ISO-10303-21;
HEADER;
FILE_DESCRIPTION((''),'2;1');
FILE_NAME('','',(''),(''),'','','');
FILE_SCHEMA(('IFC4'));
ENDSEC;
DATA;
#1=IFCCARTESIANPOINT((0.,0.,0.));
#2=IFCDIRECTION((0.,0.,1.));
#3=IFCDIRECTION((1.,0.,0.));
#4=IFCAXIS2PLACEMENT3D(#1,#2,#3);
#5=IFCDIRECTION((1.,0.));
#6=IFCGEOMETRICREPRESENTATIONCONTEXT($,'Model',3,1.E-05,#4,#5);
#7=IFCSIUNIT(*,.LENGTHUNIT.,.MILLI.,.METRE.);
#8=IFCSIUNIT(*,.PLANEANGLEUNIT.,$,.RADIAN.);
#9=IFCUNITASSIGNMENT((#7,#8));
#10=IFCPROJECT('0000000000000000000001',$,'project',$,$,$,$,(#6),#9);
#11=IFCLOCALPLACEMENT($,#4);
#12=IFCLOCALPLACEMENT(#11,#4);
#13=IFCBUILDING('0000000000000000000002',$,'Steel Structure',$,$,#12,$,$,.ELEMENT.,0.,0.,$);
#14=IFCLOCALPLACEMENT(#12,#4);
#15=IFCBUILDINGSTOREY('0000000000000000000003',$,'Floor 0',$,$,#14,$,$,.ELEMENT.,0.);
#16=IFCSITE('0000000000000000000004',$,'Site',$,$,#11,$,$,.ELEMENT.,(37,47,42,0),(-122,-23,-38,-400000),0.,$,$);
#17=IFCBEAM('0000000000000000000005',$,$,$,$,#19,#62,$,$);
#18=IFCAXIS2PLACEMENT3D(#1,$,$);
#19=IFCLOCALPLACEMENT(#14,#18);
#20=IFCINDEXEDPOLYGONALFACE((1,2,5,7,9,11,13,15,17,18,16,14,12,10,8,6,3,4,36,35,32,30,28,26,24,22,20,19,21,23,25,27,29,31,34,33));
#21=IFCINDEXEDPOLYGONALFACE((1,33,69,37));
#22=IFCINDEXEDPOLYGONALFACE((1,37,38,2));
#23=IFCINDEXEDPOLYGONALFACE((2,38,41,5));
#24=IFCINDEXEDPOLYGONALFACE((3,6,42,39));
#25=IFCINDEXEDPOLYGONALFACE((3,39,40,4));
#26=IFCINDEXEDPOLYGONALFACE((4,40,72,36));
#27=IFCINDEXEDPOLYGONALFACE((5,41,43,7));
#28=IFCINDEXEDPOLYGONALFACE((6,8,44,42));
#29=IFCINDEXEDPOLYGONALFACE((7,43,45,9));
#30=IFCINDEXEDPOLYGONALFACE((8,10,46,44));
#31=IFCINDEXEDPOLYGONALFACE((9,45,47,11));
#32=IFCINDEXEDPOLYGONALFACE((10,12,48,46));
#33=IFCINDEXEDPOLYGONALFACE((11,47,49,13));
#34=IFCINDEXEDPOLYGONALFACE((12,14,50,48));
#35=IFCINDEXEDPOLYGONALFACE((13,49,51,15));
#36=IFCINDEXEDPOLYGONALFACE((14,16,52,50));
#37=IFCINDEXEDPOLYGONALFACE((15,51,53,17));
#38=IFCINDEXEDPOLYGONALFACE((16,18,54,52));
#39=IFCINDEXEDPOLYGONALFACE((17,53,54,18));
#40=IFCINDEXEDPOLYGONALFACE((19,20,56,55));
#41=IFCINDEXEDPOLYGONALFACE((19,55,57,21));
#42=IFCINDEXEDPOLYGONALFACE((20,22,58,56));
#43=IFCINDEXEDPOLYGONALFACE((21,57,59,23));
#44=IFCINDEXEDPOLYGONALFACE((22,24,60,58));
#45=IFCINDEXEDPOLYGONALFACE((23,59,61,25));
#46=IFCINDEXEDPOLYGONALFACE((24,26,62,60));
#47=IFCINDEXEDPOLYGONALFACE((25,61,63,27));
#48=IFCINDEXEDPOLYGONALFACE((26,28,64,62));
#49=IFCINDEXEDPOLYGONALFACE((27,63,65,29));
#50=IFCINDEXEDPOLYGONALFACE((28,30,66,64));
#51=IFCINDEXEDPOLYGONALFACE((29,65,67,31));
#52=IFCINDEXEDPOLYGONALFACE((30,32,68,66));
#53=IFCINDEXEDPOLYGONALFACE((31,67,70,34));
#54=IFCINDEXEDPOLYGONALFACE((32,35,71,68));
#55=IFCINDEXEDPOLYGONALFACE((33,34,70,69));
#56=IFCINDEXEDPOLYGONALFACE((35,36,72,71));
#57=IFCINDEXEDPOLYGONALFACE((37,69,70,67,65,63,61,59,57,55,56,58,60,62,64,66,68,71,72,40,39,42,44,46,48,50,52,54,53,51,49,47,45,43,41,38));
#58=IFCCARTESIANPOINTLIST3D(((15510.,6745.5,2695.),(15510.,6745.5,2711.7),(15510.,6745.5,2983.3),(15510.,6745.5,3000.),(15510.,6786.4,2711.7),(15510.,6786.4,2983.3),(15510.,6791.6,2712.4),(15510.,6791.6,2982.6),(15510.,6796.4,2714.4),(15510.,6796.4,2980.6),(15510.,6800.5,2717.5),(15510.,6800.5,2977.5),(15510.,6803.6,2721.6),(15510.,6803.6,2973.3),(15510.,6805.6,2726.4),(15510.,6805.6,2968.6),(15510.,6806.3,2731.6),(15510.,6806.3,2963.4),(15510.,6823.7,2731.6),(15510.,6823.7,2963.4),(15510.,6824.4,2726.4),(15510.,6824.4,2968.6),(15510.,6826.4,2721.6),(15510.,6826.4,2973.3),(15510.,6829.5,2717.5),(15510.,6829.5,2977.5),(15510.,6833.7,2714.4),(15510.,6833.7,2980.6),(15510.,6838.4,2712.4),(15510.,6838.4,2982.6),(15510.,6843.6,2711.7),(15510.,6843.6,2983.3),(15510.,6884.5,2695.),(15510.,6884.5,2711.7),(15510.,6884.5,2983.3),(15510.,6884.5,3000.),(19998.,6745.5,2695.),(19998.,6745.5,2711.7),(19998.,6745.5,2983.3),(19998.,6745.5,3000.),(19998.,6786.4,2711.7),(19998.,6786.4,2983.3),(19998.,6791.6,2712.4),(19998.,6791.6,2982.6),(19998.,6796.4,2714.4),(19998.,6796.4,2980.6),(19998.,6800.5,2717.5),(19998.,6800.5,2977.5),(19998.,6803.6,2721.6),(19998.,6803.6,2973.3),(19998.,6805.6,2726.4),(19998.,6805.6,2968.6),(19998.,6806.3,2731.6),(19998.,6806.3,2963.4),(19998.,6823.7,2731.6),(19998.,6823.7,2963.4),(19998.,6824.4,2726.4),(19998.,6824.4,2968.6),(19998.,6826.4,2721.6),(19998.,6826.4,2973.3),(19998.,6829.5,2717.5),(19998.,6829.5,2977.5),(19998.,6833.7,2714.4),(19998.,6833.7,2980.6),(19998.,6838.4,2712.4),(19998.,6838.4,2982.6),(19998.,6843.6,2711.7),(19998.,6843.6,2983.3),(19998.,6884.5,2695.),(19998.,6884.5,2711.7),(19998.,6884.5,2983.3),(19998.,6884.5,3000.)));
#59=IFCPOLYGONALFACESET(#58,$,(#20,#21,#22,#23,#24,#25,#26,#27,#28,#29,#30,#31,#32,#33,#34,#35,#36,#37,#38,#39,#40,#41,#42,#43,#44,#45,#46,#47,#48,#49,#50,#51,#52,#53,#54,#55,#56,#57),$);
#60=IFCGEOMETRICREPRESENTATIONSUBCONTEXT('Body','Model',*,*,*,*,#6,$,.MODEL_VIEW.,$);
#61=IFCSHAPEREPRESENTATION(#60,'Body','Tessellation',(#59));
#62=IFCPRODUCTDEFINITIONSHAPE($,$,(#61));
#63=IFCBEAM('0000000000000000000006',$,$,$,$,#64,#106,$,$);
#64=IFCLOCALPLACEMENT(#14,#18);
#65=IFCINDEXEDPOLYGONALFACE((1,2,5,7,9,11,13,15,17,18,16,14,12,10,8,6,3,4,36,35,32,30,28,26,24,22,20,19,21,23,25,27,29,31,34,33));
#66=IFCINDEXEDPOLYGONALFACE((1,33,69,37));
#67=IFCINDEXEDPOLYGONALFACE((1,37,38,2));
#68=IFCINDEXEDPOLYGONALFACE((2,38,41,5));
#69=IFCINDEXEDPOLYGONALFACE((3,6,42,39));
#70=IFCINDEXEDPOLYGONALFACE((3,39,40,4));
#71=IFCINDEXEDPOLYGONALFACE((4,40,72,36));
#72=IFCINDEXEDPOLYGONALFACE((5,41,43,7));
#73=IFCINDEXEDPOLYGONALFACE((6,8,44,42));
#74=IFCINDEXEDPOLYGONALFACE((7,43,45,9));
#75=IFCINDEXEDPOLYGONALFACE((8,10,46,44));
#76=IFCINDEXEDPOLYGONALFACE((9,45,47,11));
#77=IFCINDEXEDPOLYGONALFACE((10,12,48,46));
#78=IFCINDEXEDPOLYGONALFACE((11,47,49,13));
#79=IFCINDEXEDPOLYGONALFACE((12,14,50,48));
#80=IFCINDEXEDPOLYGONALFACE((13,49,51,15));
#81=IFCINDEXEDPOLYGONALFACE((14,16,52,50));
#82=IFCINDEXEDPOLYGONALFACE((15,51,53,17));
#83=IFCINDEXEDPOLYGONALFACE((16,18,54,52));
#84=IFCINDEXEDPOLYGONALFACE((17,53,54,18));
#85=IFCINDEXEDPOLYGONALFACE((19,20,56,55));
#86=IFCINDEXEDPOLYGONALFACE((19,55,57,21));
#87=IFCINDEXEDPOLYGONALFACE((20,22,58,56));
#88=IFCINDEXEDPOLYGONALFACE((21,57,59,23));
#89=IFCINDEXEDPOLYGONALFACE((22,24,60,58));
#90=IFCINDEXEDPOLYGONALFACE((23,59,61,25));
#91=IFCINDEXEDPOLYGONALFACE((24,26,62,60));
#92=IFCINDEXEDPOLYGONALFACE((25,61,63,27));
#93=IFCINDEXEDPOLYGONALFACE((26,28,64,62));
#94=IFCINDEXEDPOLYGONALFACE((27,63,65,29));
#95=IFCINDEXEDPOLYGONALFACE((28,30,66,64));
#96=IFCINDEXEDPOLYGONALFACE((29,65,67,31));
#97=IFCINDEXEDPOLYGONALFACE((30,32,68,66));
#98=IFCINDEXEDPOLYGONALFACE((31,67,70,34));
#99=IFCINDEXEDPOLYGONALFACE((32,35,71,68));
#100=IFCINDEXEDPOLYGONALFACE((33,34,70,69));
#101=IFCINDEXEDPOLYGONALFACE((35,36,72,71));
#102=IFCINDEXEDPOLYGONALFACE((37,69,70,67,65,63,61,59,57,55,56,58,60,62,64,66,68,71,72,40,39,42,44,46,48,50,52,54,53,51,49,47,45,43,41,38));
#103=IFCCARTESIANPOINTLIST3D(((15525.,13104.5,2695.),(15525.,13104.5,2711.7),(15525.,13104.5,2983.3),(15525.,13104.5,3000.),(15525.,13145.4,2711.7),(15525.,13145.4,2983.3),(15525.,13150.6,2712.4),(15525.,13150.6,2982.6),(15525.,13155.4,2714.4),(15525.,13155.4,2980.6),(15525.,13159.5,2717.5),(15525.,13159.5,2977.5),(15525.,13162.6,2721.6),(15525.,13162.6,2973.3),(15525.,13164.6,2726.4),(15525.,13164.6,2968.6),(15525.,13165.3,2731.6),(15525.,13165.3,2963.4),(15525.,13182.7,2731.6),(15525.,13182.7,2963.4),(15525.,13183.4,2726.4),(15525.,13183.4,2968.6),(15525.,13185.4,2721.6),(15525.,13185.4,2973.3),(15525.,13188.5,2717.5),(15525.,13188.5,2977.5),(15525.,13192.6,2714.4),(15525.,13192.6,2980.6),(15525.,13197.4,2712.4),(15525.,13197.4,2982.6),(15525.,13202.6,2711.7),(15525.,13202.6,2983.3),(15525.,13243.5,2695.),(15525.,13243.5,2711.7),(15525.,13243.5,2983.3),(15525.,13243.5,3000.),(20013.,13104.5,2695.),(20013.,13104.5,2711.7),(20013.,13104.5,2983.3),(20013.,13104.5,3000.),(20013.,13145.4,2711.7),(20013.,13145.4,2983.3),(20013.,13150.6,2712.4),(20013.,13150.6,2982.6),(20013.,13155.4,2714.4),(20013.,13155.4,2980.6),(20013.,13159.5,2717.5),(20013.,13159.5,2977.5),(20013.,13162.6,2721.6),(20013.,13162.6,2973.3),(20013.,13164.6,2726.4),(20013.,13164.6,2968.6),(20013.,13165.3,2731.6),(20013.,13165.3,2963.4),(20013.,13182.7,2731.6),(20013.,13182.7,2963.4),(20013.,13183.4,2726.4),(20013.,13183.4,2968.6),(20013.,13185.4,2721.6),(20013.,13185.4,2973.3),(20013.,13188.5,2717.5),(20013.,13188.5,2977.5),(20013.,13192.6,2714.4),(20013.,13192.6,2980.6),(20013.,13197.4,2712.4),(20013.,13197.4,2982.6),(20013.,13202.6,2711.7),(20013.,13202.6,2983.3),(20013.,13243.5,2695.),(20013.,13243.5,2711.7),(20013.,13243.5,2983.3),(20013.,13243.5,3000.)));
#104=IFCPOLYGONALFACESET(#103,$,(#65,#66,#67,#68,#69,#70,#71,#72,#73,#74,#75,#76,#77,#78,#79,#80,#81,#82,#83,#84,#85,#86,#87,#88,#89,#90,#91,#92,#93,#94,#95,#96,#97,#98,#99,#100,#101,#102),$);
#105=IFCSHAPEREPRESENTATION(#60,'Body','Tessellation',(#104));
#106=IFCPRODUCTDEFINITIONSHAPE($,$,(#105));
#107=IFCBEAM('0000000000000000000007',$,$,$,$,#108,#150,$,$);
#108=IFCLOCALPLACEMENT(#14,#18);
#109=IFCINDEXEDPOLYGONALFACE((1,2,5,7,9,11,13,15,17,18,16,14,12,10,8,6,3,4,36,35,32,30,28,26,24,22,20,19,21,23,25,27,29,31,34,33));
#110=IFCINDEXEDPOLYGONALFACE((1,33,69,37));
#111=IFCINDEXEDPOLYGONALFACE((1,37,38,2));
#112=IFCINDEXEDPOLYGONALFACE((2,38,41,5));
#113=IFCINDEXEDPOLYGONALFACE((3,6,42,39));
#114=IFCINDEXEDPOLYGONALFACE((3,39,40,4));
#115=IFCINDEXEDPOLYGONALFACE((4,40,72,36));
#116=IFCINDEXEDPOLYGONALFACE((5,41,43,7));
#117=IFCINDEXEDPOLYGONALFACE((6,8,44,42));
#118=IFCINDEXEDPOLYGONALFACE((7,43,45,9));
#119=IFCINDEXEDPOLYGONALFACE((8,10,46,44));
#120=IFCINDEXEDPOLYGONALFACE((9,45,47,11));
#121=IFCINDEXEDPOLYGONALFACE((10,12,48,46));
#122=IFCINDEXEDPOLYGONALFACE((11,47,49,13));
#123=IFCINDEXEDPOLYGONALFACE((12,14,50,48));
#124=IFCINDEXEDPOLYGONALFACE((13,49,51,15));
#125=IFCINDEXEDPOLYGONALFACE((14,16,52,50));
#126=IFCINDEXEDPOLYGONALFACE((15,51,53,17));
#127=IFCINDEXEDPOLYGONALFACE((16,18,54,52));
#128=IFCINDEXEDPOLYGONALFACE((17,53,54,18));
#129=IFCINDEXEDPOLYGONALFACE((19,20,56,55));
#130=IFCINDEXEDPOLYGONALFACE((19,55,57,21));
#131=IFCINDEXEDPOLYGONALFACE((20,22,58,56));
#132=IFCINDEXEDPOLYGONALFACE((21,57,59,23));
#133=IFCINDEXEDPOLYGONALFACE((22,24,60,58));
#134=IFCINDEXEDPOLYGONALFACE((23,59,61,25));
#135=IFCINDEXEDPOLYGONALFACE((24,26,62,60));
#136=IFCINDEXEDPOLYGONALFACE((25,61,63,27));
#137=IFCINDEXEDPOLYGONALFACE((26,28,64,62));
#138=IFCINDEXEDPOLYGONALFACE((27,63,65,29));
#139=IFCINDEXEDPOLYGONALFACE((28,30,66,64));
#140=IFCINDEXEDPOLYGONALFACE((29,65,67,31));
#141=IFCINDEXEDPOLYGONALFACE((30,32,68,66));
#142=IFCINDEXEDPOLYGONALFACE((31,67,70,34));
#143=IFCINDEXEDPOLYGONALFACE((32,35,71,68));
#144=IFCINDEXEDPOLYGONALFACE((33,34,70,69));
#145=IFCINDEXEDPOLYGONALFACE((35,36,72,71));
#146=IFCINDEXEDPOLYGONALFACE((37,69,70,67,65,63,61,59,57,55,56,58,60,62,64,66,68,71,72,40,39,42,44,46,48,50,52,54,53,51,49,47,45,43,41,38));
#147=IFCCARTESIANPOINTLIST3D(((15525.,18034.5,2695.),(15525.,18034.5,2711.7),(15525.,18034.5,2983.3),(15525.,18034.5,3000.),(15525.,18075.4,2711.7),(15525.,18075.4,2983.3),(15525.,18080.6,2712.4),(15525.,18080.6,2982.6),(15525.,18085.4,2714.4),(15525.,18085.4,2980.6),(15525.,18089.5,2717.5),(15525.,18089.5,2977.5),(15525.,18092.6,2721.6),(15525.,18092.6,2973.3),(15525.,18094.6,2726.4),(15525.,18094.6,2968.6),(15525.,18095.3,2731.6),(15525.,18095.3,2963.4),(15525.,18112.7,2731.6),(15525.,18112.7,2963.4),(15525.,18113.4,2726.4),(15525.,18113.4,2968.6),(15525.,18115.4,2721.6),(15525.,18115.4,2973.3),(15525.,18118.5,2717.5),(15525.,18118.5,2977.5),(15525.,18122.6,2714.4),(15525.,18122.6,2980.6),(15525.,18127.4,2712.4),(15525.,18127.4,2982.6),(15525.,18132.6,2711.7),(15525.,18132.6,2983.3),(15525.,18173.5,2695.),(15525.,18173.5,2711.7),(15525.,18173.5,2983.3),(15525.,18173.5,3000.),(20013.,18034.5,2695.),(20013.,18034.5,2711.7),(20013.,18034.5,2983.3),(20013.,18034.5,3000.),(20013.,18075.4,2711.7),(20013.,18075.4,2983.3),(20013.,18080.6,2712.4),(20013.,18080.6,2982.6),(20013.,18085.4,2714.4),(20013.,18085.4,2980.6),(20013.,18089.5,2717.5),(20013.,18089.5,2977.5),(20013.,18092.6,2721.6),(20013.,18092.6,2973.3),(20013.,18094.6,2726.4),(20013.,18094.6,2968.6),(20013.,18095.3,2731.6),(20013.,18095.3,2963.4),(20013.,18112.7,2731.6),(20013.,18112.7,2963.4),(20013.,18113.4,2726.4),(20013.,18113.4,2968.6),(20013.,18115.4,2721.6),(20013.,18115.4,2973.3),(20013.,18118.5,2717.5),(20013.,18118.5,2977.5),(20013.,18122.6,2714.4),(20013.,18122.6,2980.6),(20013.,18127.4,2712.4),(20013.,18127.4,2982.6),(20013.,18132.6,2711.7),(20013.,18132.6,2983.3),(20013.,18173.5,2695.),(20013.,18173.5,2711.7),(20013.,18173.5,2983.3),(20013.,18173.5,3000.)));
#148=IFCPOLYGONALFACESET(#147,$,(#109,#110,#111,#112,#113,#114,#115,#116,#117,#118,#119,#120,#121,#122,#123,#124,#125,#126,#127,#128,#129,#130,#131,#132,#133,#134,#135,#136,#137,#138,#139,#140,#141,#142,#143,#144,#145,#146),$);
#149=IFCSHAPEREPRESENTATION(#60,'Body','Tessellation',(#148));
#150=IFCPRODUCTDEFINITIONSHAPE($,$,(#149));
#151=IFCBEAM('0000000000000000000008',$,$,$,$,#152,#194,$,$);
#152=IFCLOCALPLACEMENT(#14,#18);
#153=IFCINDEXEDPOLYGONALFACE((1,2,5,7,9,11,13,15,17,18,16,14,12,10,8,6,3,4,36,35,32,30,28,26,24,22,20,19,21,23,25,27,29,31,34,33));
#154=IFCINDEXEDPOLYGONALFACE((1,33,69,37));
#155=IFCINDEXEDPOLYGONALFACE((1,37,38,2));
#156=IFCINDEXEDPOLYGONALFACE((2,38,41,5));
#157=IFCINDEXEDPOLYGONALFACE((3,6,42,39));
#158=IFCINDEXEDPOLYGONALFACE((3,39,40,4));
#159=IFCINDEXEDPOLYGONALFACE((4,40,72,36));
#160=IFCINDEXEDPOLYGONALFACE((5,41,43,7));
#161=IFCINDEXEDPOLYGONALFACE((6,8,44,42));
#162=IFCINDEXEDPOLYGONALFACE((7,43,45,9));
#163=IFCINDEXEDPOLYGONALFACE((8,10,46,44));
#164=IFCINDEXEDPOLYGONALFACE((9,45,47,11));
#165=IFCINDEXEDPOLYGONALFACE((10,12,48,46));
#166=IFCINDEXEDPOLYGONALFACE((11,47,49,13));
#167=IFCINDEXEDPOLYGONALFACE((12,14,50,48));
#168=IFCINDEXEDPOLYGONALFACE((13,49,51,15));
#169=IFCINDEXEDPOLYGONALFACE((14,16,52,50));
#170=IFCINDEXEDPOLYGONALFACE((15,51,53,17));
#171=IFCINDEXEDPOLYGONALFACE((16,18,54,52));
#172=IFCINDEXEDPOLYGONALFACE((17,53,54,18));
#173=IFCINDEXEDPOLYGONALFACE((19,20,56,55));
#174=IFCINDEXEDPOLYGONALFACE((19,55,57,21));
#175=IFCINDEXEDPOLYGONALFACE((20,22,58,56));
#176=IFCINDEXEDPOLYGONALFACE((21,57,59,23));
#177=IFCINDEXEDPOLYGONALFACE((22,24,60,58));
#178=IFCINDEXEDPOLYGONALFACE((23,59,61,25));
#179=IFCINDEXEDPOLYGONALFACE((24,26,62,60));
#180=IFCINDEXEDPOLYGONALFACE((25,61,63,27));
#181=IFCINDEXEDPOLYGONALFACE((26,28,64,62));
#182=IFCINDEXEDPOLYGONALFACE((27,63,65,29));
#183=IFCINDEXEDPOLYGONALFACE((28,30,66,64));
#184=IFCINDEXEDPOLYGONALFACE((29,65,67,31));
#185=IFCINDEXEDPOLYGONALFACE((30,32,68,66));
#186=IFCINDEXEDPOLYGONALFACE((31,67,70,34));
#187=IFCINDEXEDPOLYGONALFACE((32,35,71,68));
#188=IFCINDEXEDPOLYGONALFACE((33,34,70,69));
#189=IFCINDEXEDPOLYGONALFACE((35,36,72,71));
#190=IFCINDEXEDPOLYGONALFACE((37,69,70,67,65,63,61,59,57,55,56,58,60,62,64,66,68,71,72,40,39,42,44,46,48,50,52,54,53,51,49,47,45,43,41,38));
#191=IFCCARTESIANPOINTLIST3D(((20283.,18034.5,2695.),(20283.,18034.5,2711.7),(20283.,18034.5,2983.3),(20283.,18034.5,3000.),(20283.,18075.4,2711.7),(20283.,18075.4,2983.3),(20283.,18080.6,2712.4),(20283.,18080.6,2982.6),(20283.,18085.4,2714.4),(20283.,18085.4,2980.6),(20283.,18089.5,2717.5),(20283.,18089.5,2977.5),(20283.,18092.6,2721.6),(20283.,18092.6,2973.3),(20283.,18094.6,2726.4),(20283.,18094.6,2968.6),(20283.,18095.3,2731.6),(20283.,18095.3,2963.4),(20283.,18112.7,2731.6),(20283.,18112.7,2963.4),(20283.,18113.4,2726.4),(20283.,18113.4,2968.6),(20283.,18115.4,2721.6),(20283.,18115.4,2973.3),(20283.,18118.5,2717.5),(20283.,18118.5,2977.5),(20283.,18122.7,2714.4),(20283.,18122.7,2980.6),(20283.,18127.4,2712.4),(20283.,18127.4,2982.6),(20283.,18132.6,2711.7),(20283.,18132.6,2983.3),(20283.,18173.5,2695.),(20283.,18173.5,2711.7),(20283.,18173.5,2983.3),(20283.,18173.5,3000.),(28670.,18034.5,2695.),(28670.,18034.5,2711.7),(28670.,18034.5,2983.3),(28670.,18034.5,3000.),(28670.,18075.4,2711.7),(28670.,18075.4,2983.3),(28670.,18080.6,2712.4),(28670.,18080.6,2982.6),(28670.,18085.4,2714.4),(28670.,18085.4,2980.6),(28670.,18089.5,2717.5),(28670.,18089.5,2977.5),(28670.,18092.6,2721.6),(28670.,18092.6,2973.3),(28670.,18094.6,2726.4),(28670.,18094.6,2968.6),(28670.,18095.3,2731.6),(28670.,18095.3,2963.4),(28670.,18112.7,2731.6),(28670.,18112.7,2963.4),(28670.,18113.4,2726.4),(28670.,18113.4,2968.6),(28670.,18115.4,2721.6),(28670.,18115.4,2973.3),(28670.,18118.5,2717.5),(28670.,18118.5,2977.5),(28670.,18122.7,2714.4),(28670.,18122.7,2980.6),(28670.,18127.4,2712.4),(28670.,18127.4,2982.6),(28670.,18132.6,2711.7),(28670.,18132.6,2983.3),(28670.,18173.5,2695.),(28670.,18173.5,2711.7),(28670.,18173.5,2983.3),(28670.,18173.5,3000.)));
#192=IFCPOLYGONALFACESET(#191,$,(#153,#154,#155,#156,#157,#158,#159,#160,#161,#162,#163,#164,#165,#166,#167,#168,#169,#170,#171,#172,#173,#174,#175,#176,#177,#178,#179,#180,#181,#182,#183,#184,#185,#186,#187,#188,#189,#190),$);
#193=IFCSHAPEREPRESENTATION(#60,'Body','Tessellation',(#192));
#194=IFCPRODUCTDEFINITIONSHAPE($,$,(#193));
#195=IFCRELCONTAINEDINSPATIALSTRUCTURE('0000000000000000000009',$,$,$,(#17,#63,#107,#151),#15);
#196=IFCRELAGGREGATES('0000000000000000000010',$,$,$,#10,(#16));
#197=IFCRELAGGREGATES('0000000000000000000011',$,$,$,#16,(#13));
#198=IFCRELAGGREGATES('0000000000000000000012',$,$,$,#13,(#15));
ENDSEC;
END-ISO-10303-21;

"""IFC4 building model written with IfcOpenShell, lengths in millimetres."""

from ifc_helpers import new_model, si_unit, direction, frame, origin_with_axes, origin_2d_with_axis, place, context, subcontext, project, spatial, i_section, extrude, element, save


model = new_model("IFC4")

# Units and contexts
model_context = context("Model", 3, precision=1e-05, world=origin_with_axes(), true_north=direction((1.0, 0.0)))
body_context = subcontext(model_context, "Body", "Model", "MODEL_VIEW")
ifc_project = project(units=[si_unit("LENGTHUNIT", "METRE", prefix="MILLI"), si_unit("PLANEANGLEUNIT", "RADIAN")], contexts=[model_context])

# Site, building, storey
site_placement = place(None, origin_with_axes())
site = spatial("IfcSite", under=ifc_project, at=site_placement, Name="Site", CompositionType="ELEMENT", RefLatitude=(37, 47, 42, 0), RefLongitude=(-122, -23, -38, -400000), RefElevation=0.0)
building_placement = place(site_placement, origin_with_axes())
building = spatial("IfcBuilding", under=site, at=building_placement, Name="Steel Structure", CompositionType="ELEMENT", ElevationOfRefHeight=0.0, ElevationOfTerrain=0.0)
storey_placement = place(building_placement, origin_with_axes())
storey = spatial("IfcBuildingStorey", under=building, at=storey_placement, Name="Floor 0", CompositionType="ELEMENT", Elevation=0.0)

# Beams
for number, where, z_axis, x_axis in (
    (1, (19998.0, 6815.0, 2695.0), (-1.0, 0.0, 0.0), (0.0, -1.0, 0.0)),
    (2, (20013.0, 13174.0, 2695.0), (-1.0, 0.0, 0.0), (0.0, -1.0, 0.0)),
    (3, (15525.0, 18104.0, 2695.0), (1.0, 0.0, 0.0), (0.0, 1.0, 0.0)),
):
    element("IfcBeam", number, at=place(storey_placement, frame(where, z_axis=z_axis, x_axis=x_axis)), inside=storey, context=body_context, shape_type="SweptSolid", body=[
        extrude(i_section(OverallWidth=139.0, OverallDepth=305.0, WebThickness=17.4, FlangeThickness=16.7, FilletRadius=19.9, at=origin_2d_with_axis()), frame((0.0, 152.5, 0.0), z_axis=(0.0, 0.0, 1.0), x_axis=(1.0, 0.0, 0.0)), (0.0, 0.0, 1.0), 4488.0),
    ])
beam_1_placement = place(storey_placement, frame((28670.0, 18104.0, 2695.0), z_axis=(-1.0, 0.0, 0.0), x_axis=(0.0, -1.0, 0.0)))
element("IfcBeam", 4, at=beam_1_placement, inside=storey, context=body_context, shape_type="SweptSolid", body=[
    extrude(i_section(OverallWidth=139.0, OverallDepth=305.0, WebThickness=17.4, FlangeThickness=16.7, FilletRadius=19.9, at=origin_2d_with_axis()), frame((0.0, 152.5, 0.0), z_axis=(0.0, 0.0, 1.0), x_axis=(1.0, 0.0, 0.0)), (0.0, 0.0, 1.0), 8387.0),
])

save(model, "model.ifc")
